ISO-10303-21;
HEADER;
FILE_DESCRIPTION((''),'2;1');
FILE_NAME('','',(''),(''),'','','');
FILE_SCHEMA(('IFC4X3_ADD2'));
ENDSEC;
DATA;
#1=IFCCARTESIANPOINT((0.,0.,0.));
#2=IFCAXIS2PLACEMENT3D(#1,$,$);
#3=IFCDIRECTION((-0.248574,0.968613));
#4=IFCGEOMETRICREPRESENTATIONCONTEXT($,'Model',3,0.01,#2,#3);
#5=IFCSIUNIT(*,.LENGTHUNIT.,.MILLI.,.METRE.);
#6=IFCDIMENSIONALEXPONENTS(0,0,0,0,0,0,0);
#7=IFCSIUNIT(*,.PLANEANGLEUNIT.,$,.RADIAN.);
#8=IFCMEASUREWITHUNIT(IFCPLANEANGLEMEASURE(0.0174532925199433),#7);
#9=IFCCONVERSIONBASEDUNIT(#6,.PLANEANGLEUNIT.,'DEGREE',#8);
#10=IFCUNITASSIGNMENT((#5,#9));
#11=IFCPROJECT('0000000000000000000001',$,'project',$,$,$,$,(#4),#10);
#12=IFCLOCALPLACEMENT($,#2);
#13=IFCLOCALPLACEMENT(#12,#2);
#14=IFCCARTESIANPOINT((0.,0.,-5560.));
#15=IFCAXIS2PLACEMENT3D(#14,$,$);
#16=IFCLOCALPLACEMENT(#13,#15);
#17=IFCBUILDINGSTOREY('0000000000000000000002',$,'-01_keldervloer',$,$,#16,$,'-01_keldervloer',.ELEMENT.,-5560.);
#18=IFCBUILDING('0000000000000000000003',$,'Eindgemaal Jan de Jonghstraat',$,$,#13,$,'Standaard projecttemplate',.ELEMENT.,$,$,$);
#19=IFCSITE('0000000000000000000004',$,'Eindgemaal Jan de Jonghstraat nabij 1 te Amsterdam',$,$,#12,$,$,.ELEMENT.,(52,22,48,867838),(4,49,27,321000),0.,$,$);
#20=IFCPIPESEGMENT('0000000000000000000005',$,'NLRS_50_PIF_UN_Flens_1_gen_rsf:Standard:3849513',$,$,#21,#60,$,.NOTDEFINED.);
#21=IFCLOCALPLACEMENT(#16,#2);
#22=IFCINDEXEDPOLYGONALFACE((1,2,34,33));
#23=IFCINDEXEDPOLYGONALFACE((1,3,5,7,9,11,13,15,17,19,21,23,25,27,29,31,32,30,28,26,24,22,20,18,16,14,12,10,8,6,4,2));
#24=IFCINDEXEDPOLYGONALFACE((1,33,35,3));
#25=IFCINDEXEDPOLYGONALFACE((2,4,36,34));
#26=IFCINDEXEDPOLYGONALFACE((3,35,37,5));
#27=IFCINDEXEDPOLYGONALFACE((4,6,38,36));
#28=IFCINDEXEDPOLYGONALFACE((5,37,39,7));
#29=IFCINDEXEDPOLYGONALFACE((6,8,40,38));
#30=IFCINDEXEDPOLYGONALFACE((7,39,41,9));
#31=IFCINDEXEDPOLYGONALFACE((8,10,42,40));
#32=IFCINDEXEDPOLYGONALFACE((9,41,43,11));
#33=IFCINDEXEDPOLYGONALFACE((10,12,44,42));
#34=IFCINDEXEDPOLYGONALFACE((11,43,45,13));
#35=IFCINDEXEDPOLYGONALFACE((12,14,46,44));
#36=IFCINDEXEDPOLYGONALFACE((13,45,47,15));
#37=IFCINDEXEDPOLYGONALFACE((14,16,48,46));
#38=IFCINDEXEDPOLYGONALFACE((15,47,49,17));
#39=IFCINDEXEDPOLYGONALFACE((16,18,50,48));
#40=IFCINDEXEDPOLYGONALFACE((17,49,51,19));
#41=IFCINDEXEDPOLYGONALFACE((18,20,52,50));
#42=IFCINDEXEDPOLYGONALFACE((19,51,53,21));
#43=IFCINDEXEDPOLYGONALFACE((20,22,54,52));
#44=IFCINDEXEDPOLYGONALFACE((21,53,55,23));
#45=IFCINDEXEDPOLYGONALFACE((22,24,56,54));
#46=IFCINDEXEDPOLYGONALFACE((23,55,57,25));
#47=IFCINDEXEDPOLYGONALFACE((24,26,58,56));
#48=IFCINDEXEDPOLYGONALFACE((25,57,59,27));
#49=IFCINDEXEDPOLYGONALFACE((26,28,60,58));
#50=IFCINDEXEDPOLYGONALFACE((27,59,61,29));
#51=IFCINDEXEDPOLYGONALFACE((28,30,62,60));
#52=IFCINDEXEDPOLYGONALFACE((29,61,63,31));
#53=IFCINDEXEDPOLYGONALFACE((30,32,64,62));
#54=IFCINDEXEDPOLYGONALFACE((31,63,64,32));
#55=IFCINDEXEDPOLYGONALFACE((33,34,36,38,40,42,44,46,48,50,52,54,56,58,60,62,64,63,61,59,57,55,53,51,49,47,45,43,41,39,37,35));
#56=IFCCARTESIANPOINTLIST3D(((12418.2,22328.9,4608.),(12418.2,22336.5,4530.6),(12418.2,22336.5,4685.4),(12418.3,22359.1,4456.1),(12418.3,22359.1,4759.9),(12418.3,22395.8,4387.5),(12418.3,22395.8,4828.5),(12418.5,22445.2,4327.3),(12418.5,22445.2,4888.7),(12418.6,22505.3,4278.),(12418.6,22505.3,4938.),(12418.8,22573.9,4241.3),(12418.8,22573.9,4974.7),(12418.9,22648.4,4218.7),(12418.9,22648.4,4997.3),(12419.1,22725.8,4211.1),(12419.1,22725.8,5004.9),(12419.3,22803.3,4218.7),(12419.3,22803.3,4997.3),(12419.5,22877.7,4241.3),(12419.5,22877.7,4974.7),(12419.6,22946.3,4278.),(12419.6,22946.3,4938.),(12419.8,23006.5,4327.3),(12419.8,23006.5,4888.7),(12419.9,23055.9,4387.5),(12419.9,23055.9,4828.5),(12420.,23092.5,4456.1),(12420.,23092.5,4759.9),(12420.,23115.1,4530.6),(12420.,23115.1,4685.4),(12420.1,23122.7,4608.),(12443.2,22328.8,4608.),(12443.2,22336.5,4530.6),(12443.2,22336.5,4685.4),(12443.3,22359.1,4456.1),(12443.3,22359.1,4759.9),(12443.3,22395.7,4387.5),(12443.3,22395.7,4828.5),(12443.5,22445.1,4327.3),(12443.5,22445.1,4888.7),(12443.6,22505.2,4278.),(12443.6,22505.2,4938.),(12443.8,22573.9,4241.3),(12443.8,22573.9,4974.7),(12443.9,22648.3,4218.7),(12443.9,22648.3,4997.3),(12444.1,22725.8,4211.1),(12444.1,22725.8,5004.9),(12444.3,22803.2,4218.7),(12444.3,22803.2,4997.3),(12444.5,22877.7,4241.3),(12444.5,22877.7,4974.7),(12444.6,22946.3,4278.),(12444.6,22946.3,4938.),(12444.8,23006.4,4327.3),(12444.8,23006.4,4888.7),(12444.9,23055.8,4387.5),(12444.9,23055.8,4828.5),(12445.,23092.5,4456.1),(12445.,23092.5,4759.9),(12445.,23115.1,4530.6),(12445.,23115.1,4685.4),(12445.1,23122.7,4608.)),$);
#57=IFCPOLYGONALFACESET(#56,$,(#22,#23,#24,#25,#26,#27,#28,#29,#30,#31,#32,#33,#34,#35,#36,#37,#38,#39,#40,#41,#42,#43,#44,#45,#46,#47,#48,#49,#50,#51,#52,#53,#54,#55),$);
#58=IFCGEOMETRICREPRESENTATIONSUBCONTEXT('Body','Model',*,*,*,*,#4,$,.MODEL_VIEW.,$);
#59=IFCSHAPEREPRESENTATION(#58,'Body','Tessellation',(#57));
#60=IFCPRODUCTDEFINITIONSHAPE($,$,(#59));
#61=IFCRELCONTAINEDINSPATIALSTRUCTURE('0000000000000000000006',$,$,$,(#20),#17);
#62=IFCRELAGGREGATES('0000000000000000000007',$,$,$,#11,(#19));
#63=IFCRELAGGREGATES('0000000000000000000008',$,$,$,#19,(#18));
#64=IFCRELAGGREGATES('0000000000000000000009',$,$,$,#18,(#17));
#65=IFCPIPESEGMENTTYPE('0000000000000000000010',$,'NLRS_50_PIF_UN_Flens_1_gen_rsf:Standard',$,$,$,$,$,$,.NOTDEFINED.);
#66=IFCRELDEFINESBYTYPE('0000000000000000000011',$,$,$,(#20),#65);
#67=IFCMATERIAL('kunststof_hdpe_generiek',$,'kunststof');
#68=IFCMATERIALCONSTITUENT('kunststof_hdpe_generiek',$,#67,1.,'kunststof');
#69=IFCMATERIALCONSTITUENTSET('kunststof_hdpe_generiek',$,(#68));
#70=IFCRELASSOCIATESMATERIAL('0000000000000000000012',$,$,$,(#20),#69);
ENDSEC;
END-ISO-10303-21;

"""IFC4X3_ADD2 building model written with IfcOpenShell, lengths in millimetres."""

from ifc_helpers import new_model, entity, si_unit, converted_unit, direction, frame, frame_2d, origin, place, context, subcontext, project, spatial, circle, extrude, source, transform, mapped, material, constituent, constituent_set, type_object, type_shapes, element, save


model = new_model("IFC4X3_ADD2")

# Units and contexts
model_context = context("Model", 3, precision=0.01, world=origin(), true_north=direction((-0.248574, 0.968613)))
body_context = subcontext(model_context, "Body", "Model", "MODEL_VIEW")
ifc_project = project(units=[si_unit("LENGTHUNIT", "METRE", prefix="MILLI"), converted_unit("PLANEANGLEUNIT", "DEGREE", entity("IfcPlaneAngleMeasure", 0.0174532925199433), si_unit("PLANEANGLEUNIT", "RADIAN"), dimensions=[0, 0, 0, 0, 0, 0, 0])], contexts=[model_context])

# Site, building, storey
site_placement = place(None, origin())
site = spatial("IfcSite", under=ifc_project, at=site_placement, Name="Eindgemaal Jan de Jonghstraat nabij 1 te Amsterdam", CompositionType="ELEMENT", RefLatitude=(52, 22, 48, 867838), RefLongitude=(4, 49, 27, 321000), RefElevation=0.0)
building_placement = place(site_placement, origin())
building = spatial("IfcBuilding", under=site, at=building_placement, Name="Eindgemaal Jan de Jonghstraat", LongName="Standaard projecttemplate", CompositionType="ELEMENT")
storey_placement = place(building_placement, frame((0.0, 0.0, -5560.0)))
storey = spatial("IfcBuildingStorey", under=building, at=storey_placement, Name="-01_keldervloer", LongName="-01_keldervloer", CompositionType="ELEMENT", Elevation=-5560.0)

# Pipe segment
ifc_material_1 = material(Name="kunststof_hdpe_generiek", Category="kunststof")
ifc_constituent_1 = constituent(ifc_material_1, Name="kunststof_hdpe_generiek", Category="kunststof", fraction=1.0)
ifc_constituent_set_1 = constituent_set(constituents=[ifc_constituent_1], Name="kunststof_hdpe_generiek")
pipe_segment_type_1 = type_object("IfcPipeSegmentType", Name="NLRS_50_PIF_UN_Flens_1_gen_rsf:Standard", PredefinedType="NOTDEFINED")
shared_shape_1 = source(origin(), body_context, "Body", "SweptSolid", [
    extrude(circle(Radius=396.9, at=frame_2d((0.0, 0.0), x_axis=(1.0, 0.0))), frame((-12.5, 0.0, 0.0), z_axis=(1.0, 0.0, 0.0), x_axis=(0.0, 1.0, 0.0)), (0.0, 0.0, 1.0), 25.0),
])
type_shapes(pipe_segment_type_1, [shared_shape_1])
for number, where, z_axis, x_axis, name in (
    (1, (12431.6, 22725.8, 4608.0), (0.0, 0.0, -1.0), (-0.999997, 0.002363, 0.0), "NLRS_50_PIF_UN_Flens_1_gen_rsf:Standard:3849513"),
):
    element("IfcPipeSegment", number, at=place(storey_placement, frame(where, z_axis=z_axis, x_axis=x_axis)), inside=storey, type_object=pipe_segment_type_1, material=ifc_constituent_set_1, Name=name, PredefinedType="NOTDEFINED", context=body_context, shape_type="MappedRepresentation", body=[
        mapped(shared_shape_1, transform((0.0, 0.0, 0.0), scale=1.0)),
    ])

save(model, "model.ifc")
